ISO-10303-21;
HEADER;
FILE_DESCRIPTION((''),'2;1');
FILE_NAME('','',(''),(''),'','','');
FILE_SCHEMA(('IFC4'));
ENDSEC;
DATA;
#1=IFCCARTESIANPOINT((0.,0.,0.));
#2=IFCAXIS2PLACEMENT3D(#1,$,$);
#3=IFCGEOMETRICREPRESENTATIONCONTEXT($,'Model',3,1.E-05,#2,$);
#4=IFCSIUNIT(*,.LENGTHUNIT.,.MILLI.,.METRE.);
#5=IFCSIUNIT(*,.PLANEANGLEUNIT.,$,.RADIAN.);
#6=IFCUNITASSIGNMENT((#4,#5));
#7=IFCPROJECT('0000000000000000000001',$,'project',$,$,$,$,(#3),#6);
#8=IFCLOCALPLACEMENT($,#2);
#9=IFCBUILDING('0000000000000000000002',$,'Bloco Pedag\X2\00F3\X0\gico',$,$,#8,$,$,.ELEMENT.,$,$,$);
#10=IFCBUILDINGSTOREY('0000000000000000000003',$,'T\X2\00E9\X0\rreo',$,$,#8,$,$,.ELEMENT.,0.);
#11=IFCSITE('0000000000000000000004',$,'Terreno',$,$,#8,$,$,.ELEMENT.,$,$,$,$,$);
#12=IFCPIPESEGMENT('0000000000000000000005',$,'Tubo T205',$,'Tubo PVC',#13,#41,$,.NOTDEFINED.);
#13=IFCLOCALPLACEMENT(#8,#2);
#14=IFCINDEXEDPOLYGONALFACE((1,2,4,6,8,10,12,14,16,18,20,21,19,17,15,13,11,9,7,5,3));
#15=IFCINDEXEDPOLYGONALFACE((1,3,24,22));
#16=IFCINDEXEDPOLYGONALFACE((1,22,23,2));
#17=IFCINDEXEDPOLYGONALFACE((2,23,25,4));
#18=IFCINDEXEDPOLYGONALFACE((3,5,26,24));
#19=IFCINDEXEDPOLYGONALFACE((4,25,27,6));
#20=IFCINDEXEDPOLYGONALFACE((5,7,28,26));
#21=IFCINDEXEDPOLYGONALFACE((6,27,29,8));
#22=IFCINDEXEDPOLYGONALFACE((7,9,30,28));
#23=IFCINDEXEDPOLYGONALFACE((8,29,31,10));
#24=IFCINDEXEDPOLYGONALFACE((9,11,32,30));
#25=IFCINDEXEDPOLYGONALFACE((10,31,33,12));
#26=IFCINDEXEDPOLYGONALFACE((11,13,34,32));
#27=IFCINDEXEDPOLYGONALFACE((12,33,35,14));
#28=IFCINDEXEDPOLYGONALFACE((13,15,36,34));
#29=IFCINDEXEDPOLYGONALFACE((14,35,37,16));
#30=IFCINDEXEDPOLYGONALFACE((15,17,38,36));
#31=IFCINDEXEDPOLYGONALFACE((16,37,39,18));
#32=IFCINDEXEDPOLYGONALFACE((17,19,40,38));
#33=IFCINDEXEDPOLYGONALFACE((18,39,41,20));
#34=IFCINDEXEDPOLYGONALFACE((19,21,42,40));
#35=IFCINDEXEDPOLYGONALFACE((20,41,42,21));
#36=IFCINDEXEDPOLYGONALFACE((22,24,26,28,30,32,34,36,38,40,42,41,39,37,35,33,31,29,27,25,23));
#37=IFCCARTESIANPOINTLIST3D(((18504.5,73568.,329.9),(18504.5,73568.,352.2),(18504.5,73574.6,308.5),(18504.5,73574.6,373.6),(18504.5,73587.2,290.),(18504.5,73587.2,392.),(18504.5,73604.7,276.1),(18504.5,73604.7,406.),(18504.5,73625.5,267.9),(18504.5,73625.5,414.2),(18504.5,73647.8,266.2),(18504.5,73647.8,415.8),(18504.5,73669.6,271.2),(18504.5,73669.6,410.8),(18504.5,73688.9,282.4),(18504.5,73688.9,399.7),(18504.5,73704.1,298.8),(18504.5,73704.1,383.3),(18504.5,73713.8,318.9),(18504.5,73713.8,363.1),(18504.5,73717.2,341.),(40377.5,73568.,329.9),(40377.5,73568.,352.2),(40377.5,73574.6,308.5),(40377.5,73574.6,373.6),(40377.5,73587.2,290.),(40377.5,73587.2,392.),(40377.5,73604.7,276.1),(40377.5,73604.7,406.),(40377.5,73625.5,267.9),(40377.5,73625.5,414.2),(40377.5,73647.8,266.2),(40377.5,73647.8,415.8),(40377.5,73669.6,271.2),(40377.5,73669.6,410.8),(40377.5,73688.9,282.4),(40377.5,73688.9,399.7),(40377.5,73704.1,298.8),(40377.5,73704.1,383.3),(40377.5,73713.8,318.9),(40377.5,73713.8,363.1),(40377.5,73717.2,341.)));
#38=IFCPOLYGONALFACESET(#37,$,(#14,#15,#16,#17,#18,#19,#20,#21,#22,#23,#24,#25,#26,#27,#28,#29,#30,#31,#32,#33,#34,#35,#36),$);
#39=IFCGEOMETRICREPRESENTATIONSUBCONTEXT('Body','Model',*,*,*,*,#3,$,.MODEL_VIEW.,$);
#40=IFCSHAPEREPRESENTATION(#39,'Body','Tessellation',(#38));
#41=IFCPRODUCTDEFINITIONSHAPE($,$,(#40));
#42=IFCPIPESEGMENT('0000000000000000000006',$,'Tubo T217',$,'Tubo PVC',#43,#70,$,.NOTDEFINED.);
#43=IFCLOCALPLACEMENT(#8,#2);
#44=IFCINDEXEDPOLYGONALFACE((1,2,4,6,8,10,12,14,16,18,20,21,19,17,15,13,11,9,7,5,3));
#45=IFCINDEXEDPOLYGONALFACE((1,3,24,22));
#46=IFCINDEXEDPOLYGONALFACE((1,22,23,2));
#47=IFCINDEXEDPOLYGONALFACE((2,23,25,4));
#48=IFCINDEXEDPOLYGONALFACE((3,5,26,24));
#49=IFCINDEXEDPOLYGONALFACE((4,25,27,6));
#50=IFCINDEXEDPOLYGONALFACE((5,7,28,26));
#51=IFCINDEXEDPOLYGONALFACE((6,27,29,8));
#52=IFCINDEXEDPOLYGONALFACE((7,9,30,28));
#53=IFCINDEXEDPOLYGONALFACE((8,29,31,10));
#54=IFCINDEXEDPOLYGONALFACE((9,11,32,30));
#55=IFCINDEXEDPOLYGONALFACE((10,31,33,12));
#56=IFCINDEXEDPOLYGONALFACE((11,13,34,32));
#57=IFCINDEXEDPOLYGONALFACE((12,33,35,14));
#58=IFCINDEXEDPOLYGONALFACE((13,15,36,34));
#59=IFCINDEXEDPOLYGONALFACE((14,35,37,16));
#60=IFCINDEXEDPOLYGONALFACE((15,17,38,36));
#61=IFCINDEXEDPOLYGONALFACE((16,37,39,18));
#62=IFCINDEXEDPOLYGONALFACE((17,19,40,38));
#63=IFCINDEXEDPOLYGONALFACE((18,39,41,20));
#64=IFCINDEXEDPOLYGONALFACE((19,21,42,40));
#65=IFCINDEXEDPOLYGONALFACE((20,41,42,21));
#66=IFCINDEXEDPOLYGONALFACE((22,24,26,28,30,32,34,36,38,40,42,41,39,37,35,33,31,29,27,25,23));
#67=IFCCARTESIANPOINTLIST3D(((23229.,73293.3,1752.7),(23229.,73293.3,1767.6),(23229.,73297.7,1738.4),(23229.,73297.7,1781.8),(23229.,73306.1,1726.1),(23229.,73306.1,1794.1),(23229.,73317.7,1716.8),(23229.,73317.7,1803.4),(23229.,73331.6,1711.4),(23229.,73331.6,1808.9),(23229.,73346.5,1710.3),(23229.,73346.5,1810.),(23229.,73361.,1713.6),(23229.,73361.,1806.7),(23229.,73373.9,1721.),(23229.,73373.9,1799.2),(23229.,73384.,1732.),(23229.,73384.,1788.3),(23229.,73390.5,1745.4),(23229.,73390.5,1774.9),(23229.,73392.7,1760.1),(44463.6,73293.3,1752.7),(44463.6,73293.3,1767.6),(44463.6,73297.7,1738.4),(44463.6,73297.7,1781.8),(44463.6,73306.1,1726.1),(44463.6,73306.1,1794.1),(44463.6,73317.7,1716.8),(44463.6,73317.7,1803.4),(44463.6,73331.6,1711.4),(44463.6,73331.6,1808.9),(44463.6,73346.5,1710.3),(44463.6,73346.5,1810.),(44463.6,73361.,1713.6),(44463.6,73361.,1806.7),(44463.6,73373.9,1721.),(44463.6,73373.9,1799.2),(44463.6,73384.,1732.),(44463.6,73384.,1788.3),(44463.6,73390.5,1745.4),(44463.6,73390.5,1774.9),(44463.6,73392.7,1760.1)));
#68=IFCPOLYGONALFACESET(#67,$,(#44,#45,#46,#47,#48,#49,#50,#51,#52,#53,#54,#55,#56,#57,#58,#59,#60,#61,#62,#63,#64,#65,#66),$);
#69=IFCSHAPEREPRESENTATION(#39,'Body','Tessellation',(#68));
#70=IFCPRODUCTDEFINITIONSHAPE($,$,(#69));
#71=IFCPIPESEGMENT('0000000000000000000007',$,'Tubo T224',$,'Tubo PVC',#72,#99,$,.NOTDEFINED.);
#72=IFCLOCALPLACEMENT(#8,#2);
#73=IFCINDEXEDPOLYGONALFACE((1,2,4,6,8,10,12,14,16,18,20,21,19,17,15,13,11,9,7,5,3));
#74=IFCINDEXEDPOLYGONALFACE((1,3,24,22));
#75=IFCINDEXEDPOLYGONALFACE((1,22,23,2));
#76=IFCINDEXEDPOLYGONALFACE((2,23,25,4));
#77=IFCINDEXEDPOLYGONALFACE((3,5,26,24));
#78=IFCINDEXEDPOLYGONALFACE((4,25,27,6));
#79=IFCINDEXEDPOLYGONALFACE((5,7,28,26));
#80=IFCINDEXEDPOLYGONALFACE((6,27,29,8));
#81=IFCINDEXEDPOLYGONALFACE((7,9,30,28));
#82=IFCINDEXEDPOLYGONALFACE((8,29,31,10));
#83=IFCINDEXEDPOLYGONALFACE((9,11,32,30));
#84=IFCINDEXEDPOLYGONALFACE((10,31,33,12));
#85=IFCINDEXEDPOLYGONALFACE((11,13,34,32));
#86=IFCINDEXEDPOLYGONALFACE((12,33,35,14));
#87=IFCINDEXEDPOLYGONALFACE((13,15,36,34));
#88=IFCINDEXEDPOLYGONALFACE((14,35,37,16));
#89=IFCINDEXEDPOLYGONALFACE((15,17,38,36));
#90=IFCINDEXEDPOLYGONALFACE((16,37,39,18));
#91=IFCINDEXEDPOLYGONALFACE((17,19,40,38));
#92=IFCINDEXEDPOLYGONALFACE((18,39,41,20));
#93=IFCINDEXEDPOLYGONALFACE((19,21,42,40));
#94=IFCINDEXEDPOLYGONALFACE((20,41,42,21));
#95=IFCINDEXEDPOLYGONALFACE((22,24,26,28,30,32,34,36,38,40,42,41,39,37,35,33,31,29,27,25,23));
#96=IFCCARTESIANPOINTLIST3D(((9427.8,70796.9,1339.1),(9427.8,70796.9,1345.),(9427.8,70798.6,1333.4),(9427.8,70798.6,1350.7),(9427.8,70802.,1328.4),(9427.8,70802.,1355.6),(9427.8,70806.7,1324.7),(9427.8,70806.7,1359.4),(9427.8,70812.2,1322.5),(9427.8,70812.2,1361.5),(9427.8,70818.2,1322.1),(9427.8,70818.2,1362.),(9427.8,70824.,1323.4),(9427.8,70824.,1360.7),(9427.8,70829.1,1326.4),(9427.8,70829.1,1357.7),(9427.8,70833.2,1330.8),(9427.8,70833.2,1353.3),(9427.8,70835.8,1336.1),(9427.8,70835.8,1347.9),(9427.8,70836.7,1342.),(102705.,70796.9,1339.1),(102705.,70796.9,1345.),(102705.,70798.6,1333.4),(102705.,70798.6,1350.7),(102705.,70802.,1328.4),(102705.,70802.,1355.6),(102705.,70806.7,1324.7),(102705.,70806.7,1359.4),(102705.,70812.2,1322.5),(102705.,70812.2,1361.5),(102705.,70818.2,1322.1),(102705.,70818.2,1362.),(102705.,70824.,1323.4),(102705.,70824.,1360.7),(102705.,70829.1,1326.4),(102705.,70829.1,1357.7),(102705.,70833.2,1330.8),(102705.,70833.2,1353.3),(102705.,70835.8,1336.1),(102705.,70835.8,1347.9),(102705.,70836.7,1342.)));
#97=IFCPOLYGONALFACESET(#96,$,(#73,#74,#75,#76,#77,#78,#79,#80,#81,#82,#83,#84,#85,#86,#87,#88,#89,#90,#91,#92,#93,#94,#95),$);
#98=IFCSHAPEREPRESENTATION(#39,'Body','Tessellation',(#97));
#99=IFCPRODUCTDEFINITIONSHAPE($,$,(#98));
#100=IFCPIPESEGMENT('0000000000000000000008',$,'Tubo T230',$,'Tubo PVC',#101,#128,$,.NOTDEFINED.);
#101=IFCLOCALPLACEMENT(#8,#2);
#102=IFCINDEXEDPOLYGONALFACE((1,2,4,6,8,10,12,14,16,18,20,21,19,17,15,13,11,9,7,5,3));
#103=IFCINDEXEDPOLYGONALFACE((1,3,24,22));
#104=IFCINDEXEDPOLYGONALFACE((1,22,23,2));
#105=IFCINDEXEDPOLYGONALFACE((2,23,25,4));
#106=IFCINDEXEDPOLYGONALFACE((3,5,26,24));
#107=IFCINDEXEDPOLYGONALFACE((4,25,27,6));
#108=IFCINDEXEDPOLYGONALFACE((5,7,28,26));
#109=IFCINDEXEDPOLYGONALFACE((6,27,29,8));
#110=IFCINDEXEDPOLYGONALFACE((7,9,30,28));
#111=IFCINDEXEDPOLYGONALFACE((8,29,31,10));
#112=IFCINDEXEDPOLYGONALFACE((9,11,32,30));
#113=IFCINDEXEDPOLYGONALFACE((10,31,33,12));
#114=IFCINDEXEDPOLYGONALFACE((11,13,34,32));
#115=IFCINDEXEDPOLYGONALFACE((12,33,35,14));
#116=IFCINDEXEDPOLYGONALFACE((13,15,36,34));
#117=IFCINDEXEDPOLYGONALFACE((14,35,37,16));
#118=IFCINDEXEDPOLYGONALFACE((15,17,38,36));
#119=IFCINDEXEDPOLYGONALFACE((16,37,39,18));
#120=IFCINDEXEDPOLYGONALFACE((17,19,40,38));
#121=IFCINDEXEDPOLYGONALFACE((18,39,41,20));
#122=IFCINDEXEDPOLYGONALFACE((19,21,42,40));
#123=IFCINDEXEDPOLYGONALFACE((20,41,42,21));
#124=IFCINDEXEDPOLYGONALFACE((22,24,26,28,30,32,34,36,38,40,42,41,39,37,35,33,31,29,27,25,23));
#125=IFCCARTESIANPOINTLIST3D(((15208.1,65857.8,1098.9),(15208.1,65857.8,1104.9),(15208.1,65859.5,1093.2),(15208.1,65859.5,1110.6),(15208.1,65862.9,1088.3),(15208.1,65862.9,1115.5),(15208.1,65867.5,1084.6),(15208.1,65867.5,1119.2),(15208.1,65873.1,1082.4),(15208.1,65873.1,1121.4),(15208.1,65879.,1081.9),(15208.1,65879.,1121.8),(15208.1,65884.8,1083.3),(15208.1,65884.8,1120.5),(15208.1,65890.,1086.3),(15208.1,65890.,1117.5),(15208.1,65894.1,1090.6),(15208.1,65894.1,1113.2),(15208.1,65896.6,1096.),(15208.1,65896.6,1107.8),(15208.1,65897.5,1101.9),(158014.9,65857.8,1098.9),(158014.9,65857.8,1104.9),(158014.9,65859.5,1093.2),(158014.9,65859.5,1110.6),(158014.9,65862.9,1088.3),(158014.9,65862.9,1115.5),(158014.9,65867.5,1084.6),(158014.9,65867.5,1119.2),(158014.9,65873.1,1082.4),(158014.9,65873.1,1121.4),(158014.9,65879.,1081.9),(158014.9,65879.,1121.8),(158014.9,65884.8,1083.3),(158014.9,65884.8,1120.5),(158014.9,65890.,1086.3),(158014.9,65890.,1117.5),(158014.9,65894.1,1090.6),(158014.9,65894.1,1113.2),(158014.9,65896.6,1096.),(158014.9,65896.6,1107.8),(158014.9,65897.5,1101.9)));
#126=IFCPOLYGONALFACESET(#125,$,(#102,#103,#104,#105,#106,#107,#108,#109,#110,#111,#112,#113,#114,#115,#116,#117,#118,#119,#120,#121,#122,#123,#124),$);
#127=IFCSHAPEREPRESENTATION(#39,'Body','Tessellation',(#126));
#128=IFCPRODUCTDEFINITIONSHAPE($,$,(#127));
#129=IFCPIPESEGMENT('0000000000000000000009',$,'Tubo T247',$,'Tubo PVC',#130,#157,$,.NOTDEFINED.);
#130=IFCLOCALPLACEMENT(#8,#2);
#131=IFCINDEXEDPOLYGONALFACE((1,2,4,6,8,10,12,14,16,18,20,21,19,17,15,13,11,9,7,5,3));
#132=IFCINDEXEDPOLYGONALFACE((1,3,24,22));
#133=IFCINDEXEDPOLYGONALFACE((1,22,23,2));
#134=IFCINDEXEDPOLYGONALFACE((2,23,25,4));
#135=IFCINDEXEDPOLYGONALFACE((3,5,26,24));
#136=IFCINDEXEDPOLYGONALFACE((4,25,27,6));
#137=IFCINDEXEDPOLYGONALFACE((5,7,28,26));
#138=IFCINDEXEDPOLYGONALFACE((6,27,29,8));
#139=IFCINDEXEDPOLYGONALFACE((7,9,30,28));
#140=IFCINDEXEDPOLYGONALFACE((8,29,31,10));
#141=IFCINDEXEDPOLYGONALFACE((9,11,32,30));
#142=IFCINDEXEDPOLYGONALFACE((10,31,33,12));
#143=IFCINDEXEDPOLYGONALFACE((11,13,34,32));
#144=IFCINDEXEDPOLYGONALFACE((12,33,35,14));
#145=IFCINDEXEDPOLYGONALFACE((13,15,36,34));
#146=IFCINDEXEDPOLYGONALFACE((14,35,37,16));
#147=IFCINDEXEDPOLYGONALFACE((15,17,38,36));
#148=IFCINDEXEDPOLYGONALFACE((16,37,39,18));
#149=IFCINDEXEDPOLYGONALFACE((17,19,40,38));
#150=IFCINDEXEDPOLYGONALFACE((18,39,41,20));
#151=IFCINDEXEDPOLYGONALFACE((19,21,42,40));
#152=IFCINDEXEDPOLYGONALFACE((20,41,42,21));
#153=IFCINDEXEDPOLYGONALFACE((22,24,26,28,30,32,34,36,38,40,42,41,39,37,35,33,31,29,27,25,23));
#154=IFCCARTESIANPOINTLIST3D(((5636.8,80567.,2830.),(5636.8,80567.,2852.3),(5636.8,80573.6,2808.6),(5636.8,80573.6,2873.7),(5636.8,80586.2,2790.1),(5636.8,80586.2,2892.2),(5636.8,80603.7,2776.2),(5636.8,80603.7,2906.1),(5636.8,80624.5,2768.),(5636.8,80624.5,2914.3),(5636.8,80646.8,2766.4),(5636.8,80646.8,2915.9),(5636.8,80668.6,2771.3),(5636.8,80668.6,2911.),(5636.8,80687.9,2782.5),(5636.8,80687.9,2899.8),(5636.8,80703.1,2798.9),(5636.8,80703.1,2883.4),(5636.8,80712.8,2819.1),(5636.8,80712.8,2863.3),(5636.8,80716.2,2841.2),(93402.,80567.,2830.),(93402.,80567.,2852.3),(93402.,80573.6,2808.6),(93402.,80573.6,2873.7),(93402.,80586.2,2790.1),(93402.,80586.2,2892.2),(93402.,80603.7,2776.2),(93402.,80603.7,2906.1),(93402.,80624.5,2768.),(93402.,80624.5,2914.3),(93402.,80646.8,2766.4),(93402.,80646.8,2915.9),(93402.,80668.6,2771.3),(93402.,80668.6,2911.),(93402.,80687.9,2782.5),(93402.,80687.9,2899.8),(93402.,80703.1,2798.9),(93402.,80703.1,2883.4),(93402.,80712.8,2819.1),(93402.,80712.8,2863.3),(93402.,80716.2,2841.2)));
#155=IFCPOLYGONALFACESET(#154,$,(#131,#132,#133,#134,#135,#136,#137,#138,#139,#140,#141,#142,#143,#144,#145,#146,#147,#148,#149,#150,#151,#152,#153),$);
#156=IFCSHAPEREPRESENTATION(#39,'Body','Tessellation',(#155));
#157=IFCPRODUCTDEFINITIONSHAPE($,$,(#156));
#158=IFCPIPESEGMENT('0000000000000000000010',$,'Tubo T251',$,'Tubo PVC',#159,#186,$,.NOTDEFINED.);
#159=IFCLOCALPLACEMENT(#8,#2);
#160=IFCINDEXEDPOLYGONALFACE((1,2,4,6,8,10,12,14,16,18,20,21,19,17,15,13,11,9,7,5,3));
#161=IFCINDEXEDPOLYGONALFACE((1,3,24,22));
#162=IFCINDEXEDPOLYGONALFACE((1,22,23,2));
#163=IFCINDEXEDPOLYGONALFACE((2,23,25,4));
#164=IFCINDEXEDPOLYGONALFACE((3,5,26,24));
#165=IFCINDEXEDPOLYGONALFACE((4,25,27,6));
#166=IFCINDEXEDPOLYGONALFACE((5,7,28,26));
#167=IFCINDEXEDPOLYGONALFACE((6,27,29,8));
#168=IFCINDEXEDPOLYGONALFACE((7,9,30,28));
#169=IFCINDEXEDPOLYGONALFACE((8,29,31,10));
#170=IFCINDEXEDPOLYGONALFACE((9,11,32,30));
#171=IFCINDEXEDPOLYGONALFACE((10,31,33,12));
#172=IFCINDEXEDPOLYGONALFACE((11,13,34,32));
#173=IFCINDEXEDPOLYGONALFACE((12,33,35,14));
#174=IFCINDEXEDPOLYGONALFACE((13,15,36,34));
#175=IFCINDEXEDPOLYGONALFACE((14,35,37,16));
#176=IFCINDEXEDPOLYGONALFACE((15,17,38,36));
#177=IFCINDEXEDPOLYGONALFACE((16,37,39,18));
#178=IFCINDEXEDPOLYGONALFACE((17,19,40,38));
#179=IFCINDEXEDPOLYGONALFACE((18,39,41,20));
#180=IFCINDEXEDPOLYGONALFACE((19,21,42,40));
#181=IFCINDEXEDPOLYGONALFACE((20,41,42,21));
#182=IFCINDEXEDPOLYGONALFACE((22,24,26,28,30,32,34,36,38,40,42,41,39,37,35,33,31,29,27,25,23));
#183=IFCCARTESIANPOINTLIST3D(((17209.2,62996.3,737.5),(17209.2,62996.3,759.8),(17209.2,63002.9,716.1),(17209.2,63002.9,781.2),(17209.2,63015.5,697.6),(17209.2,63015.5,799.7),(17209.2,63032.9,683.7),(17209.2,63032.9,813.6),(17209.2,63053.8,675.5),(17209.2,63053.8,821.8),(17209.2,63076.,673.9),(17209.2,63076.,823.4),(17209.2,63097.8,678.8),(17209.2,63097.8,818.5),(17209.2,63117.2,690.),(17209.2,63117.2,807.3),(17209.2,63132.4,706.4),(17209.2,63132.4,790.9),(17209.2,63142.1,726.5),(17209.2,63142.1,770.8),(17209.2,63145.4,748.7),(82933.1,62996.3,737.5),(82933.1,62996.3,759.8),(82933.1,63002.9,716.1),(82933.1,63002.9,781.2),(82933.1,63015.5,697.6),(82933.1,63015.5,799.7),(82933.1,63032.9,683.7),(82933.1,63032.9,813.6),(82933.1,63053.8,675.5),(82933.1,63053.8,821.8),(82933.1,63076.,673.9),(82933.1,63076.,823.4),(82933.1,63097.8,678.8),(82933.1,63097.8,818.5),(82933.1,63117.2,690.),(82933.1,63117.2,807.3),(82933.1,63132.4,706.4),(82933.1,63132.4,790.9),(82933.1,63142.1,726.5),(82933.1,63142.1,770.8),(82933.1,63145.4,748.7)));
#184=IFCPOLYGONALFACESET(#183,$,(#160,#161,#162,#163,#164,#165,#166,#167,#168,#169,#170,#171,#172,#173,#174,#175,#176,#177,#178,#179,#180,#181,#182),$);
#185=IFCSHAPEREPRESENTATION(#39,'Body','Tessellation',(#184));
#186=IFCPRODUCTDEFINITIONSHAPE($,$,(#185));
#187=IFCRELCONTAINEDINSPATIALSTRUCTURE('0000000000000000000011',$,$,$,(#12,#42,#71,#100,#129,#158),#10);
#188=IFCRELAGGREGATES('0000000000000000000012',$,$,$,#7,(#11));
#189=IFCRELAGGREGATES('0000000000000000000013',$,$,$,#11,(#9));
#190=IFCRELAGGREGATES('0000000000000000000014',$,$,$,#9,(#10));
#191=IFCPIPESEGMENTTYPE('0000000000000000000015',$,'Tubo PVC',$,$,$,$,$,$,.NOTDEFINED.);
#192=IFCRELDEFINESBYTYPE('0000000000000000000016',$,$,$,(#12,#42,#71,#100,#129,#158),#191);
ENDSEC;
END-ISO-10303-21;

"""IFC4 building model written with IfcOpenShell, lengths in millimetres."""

from ifc_helpers import new_model, si_unit, frame, origin, origin_2d, place, context, subcontext, project, spatial, circle, extrude, type_object, element, save


model = new_model("IFC4")

# Units and contexts
model_context = context("Model", 3, precision=1e-05, world=origin())
body_context = subcontext(model_context, "Body", "Model", "MODEL_VIEW")
ifc_project = project(units=[si_unit("LENGTHUNIT", "METRE", prefix="MILLI"), si_unit("PLANEANGLEUNIT", "RADIAN")], contexts=[model_context])

# Site, building, storey
placement = place(None, origin())
site = spatial("IfcSite", under=ifc_project, at=placement, Name="Terreno", CompositionType="ELEMENT")
building = spatial("IfcBuilding", under=site, at=placement, Name="Bloco Pedagógico", CompositionType="ELEMENT")
storey = spatial("IfcBuildingStorey", under=building, at=placement, Name="Térreo", CompositionType="ELEMENT", Elevation=0.0)

# Pipe segments
pipe_segment_type = type_object("IfcPipeSegmentType", Name="Tubo PVC", PredefinedType="NOTDEFINED")
pipe_segment_1_placement = place(None, frame((18504.5, 73642.2, 341.0), z_axis=(1.0, 0.0, 0.0), x_axis=(0.0, 1.0, 0.0)))
element("IfcPipeSegment", 1, at=pipe_segment_1_placement, inside=storey, type_object=pipe_segment_type, Name="Tubo T205", ObjectType="Tubo PVC", PredefinedType="NOTDEFINED", context=body_context, shape_type="SweptSolid", body=[
    extrude(circle(Radius=75.0, at=origin_2d()), None, (0.0, 0.0, 1.0), 21873.0),
])
pipe_segment_2_placement = place(None, frame((23229.0, 73342.7, 1760.1), z_axis=(1.0, 0.0, 0.0), x_axis=(0.0, 1.0, 0.0)))
element("IfcPipeSegment", 2, at=pipe_segment_2_placement, inside=storey, type_object=pipe_segment_type, Name="Tubo T217", ObjectType="Tubo PVC", PredefinedType="NOTDEFINED", context=body_context, shape_type="SweptSolid", body=[
    extrude(circle(Radius=50.0, at=origin_2d()), None, (0.0, 0.0, 1.0), 21234.6),
])
pipe_segment_3_placement = place(None, frame((9427.8, 70816.7, 1342.0), z_axis=(1.0, 0.0, 0.0), x_axis=(0.0, 1.0, 0.0)))
element("IfcPipeSegment", 3, at=pipe_segment_3_placement, inside=storey, type_object=pipe_segment_type, Name="Tubo T224", ObjectType="Tubo PVC", PredefinedType="NOTDEFINED", context=body_context, shape_type="SweptSolid", body=[
    extrude(circle(Radius=20.0, at=origin_2d()), None, (0.0, 0.0, 1.0), 93277.3),
])
pipe_segment_4_placement = place(None, frame((15208.1, 65877.5, 1101.9), z_axis=(1.0, 0.0, 0.0), x_axis=(0.0, 1.0, 0.0)))
element("IfcPipeSegment", 4, at=pipe_segment_4_placement, inside=storey, type_object=pipe_segment_type, Name="Tubo T230", ObjectType="Tubo PVC", PredefinedType="NOTDEFINED", context=body_context, shape_type="SweptSolid", body=[
    extrude(circle(Radius=20.0, at=origin_2d()), None, (0.0, 0.0, 1.0), 142806.8),
])
pipe_segment_5_placement = place(None, frame((5636.8, 80641.2, 2841.2), z_axis=(1.0, 0.0, 0.0), x_axis=(0.0, 1.0, 0.0)))
element("IfcPipeSegment", 5, at=pipe_segment_5_placement, inside=storey, type_object=pipe_segment_type, Name="Tubo T247", ObjectType="Tubo PVC", PredefinedType="NOTDEFINED", context=body_context, shape_type="SweptSolid", body=[
    extrude(circle(Radius=75.0, at=origin_2d()), None, (0.0, 0.0, 1.0), 87765.3),
])
pipe_segment_6_placement = place(None, frame((17209.2, 63070.4, 748.7), z_axis=(1.0, 0.0, 0.0), x_axis=(0.0, 1.0, 0.0)))
element("IfcPipeSegment", 6, at=pipe_segment_6_placement, inside=storey, type_object=pipe_segment_type, Name="Tubo T251", ObjectType="Tubo PVC", PredefinedType="NOTDEFINED", context=body_context, shape_type="SweptSolid", body=[
    extrude(circle(Radius=75.0, at=origin_2d()), None, (0.0, 0.0, 1.0), 65723.9),
])

save(model, "model.ifc")
